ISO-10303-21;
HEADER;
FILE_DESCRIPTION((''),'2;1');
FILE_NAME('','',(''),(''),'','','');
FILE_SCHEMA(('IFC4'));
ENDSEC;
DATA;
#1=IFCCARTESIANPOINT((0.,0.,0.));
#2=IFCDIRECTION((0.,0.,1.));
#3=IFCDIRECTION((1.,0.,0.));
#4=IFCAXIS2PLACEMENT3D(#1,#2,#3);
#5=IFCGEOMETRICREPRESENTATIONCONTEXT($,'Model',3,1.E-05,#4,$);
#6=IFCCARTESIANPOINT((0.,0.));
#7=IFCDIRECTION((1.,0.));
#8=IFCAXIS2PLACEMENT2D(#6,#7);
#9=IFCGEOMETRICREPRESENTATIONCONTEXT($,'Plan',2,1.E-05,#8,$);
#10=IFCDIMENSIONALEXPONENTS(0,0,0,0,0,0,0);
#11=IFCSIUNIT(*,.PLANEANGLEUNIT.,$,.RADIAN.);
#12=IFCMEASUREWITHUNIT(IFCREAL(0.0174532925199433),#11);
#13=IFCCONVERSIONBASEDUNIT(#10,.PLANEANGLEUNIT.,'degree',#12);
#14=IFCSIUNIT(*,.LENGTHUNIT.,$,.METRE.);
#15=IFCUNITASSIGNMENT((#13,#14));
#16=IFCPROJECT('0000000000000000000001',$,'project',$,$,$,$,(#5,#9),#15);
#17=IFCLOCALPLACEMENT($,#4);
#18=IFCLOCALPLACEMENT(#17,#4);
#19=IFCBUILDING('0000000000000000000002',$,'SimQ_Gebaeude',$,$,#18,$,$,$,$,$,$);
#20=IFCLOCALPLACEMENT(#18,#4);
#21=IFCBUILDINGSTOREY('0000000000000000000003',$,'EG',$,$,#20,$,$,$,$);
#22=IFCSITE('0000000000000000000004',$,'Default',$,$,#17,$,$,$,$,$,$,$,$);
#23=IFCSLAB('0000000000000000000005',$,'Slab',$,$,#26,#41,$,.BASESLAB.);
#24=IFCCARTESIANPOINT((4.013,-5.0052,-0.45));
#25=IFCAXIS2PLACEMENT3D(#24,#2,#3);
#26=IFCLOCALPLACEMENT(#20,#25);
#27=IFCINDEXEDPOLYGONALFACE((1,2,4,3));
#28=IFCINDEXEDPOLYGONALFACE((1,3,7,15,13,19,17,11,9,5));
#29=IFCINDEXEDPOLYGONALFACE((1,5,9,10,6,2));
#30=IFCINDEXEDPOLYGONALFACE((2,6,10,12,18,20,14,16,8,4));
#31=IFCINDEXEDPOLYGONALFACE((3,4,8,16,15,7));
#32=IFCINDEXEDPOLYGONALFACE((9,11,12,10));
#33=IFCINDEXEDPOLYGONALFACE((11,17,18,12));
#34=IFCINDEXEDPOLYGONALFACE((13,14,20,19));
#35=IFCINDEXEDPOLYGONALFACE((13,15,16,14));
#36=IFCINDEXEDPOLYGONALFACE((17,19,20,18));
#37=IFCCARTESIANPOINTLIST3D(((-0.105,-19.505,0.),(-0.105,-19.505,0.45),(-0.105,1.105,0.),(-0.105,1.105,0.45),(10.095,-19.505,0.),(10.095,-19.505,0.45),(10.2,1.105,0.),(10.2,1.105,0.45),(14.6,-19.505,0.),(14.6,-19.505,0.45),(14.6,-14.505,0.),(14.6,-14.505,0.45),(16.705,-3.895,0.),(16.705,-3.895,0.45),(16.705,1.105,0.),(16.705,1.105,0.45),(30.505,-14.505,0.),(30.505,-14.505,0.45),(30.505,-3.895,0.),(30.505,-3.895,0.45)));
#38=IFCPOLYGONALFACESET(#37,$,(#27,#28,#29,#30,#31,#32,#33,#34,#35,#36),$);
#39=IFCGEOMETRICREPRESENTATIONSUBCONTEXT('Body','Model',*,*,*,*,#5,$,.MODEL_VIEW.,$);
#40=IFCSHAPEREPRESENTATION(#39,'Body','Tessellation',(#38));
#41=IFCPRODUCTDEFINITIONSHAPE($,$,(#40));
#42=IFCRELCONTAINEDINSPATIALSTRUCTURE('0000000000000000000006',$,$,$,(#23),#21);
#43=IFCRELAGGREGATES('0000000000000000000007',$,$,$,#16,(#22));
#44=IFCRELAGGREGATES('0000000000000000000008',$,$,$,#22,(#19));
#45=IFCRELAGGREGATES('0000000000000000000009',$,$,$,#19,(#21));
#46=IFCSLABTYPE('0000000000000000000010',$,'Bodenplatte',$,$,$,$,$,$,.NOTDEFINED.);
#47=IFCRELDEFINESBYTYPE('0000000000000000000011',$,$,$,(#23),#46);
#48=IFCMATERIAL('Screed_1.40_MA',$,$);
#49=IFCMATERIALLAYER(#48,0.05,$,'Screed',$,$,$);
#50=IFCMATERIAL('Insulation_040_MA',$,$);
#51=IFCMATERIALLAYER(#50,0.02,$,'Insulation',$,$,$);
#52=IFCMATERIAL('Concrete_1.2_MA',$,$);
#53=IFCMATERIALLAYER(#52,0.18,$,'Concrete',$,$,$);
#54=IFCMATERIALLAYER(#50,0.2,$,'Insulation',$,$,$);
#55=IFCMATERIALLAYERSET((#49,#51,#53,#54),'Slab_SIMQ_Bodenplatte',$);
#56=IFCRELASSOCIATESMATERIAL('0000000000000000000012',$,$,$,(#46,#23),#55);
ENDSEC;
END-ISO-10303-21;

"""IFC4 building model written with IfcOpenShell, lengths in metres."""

from ifc_helpers import new_model, entity, si_unit, converted_unit, frame, origin_with_axes, origin_2d_with_axis, place, context, subcontext, project, spatial, line, indexed_curve, outline, extrude, material, layer, layer_set, layer_usage, type_object, element, save


model = new_model("IFC4")

# Units and contexts
model_context = context("Model", 3, precision=1e-05, world=origin_with_axes())
plan_context = context("Plan", 2, precision=1e-05, world=origin_2d_with_axis())
body_context_1 = subcontext(model_context, "Body", "Model", "MODEL_VIEW")
ifc_project = project(units=[converted_unit("PLANEANGLEUNIT", "degree", entity("IfcReal", 0.0174532925199433), si_unit("PLANEANGLEUNIT", "RADIAN"), dimensions=[0, 0, 0, 0, 0, 0, 0]), si_unit("LENGTHUNIT", "METRE")], contexts=[model_context, plan_context])

# Site, building, storey
site_placement = place(None, origin_with_axes())
site = spatial("IfcSite", under=ifc_project, at=site_placement, Name="Default")
building_placement = place(site_placement, origin_with_axes())
building = spatial("IfcBuilding", under=site, at=building_placement, Name="SimQ_Gebaeude")
storey_placement = place(building_placement, origin_with_axes())
storey = spatial("IfcBuildingStorey", under=building, at=storey_placement, Name="EG")

# Slab
ifc_material_1 = material(Name="Screed_1.40_MA")
ifc_layer_1 = layer(ifc_material_1, 0.05, Name="Screed")
ifc_material_2 = material(Name="Insulation_040_MA")
ifc_layer_2 = layer(ifc_material_2, 0.02, Name="Insulation")
ifc_material_3 = material(Name="Concrete_1.2_MA")
ifc_layer_3 = layer(ifc_material_3, 0.18, Name="Concrete")
ifc_layer_4 = layer(ifc_material_2, 0.2, Name="Insulation")
ifc_layer_set_1 = layer_set([ifc_layer_1, ifc_layer_2, ifc_layer_3, ifc_layer_4], Name="Slab_SIMQ_Bodenplatte")
ifc_layer_usage_1 = layer_usage(ifc_layer_set_1, "AXIS3", "POSITIVE", 0.0)
slab_type = type_object("IfcSlabType", Name="Bodenplatte", PredefinedType="NOTDEFINED", material=ifc_layer_set_1)
slab_placement = place(storey_placement, frame((4.013, -5.0052, -0.45), z_axis=(0.0, 0.0, 1.0), x_axis=(1.0, 0.0, 0.0)))
element("IfcSlab", 1, at=slab_placement, inside=storey, type_object=slab_type, material=ifc_layer_usage_1, Name="Slab", PredefinedType="BASESLAB", context=body_context_1, shape_type="SweptSolid", body=[
    extrude(outline(indexed_curve([(14.6, -19.505), (10.095, -19.505), (-0.105, -19.505), (-0.105, 1.105), (10.2, 1.105), (16.705, 1.105), (16.705, -3.895), (30.505, -3.895), (30.505, -14.505), (14.6, -14.505)], segments=[line(7, 6), line(6, 5), line(5, 4), line(4, 3), line(3, 2), line(2, 1), line(1, 10), line(10, 9), line(9, 8), line(8, 7)], self_intersect=False)), None, (0.0, 0.0, 1.0), 0.45),
])

save(model, "model.ifc")
